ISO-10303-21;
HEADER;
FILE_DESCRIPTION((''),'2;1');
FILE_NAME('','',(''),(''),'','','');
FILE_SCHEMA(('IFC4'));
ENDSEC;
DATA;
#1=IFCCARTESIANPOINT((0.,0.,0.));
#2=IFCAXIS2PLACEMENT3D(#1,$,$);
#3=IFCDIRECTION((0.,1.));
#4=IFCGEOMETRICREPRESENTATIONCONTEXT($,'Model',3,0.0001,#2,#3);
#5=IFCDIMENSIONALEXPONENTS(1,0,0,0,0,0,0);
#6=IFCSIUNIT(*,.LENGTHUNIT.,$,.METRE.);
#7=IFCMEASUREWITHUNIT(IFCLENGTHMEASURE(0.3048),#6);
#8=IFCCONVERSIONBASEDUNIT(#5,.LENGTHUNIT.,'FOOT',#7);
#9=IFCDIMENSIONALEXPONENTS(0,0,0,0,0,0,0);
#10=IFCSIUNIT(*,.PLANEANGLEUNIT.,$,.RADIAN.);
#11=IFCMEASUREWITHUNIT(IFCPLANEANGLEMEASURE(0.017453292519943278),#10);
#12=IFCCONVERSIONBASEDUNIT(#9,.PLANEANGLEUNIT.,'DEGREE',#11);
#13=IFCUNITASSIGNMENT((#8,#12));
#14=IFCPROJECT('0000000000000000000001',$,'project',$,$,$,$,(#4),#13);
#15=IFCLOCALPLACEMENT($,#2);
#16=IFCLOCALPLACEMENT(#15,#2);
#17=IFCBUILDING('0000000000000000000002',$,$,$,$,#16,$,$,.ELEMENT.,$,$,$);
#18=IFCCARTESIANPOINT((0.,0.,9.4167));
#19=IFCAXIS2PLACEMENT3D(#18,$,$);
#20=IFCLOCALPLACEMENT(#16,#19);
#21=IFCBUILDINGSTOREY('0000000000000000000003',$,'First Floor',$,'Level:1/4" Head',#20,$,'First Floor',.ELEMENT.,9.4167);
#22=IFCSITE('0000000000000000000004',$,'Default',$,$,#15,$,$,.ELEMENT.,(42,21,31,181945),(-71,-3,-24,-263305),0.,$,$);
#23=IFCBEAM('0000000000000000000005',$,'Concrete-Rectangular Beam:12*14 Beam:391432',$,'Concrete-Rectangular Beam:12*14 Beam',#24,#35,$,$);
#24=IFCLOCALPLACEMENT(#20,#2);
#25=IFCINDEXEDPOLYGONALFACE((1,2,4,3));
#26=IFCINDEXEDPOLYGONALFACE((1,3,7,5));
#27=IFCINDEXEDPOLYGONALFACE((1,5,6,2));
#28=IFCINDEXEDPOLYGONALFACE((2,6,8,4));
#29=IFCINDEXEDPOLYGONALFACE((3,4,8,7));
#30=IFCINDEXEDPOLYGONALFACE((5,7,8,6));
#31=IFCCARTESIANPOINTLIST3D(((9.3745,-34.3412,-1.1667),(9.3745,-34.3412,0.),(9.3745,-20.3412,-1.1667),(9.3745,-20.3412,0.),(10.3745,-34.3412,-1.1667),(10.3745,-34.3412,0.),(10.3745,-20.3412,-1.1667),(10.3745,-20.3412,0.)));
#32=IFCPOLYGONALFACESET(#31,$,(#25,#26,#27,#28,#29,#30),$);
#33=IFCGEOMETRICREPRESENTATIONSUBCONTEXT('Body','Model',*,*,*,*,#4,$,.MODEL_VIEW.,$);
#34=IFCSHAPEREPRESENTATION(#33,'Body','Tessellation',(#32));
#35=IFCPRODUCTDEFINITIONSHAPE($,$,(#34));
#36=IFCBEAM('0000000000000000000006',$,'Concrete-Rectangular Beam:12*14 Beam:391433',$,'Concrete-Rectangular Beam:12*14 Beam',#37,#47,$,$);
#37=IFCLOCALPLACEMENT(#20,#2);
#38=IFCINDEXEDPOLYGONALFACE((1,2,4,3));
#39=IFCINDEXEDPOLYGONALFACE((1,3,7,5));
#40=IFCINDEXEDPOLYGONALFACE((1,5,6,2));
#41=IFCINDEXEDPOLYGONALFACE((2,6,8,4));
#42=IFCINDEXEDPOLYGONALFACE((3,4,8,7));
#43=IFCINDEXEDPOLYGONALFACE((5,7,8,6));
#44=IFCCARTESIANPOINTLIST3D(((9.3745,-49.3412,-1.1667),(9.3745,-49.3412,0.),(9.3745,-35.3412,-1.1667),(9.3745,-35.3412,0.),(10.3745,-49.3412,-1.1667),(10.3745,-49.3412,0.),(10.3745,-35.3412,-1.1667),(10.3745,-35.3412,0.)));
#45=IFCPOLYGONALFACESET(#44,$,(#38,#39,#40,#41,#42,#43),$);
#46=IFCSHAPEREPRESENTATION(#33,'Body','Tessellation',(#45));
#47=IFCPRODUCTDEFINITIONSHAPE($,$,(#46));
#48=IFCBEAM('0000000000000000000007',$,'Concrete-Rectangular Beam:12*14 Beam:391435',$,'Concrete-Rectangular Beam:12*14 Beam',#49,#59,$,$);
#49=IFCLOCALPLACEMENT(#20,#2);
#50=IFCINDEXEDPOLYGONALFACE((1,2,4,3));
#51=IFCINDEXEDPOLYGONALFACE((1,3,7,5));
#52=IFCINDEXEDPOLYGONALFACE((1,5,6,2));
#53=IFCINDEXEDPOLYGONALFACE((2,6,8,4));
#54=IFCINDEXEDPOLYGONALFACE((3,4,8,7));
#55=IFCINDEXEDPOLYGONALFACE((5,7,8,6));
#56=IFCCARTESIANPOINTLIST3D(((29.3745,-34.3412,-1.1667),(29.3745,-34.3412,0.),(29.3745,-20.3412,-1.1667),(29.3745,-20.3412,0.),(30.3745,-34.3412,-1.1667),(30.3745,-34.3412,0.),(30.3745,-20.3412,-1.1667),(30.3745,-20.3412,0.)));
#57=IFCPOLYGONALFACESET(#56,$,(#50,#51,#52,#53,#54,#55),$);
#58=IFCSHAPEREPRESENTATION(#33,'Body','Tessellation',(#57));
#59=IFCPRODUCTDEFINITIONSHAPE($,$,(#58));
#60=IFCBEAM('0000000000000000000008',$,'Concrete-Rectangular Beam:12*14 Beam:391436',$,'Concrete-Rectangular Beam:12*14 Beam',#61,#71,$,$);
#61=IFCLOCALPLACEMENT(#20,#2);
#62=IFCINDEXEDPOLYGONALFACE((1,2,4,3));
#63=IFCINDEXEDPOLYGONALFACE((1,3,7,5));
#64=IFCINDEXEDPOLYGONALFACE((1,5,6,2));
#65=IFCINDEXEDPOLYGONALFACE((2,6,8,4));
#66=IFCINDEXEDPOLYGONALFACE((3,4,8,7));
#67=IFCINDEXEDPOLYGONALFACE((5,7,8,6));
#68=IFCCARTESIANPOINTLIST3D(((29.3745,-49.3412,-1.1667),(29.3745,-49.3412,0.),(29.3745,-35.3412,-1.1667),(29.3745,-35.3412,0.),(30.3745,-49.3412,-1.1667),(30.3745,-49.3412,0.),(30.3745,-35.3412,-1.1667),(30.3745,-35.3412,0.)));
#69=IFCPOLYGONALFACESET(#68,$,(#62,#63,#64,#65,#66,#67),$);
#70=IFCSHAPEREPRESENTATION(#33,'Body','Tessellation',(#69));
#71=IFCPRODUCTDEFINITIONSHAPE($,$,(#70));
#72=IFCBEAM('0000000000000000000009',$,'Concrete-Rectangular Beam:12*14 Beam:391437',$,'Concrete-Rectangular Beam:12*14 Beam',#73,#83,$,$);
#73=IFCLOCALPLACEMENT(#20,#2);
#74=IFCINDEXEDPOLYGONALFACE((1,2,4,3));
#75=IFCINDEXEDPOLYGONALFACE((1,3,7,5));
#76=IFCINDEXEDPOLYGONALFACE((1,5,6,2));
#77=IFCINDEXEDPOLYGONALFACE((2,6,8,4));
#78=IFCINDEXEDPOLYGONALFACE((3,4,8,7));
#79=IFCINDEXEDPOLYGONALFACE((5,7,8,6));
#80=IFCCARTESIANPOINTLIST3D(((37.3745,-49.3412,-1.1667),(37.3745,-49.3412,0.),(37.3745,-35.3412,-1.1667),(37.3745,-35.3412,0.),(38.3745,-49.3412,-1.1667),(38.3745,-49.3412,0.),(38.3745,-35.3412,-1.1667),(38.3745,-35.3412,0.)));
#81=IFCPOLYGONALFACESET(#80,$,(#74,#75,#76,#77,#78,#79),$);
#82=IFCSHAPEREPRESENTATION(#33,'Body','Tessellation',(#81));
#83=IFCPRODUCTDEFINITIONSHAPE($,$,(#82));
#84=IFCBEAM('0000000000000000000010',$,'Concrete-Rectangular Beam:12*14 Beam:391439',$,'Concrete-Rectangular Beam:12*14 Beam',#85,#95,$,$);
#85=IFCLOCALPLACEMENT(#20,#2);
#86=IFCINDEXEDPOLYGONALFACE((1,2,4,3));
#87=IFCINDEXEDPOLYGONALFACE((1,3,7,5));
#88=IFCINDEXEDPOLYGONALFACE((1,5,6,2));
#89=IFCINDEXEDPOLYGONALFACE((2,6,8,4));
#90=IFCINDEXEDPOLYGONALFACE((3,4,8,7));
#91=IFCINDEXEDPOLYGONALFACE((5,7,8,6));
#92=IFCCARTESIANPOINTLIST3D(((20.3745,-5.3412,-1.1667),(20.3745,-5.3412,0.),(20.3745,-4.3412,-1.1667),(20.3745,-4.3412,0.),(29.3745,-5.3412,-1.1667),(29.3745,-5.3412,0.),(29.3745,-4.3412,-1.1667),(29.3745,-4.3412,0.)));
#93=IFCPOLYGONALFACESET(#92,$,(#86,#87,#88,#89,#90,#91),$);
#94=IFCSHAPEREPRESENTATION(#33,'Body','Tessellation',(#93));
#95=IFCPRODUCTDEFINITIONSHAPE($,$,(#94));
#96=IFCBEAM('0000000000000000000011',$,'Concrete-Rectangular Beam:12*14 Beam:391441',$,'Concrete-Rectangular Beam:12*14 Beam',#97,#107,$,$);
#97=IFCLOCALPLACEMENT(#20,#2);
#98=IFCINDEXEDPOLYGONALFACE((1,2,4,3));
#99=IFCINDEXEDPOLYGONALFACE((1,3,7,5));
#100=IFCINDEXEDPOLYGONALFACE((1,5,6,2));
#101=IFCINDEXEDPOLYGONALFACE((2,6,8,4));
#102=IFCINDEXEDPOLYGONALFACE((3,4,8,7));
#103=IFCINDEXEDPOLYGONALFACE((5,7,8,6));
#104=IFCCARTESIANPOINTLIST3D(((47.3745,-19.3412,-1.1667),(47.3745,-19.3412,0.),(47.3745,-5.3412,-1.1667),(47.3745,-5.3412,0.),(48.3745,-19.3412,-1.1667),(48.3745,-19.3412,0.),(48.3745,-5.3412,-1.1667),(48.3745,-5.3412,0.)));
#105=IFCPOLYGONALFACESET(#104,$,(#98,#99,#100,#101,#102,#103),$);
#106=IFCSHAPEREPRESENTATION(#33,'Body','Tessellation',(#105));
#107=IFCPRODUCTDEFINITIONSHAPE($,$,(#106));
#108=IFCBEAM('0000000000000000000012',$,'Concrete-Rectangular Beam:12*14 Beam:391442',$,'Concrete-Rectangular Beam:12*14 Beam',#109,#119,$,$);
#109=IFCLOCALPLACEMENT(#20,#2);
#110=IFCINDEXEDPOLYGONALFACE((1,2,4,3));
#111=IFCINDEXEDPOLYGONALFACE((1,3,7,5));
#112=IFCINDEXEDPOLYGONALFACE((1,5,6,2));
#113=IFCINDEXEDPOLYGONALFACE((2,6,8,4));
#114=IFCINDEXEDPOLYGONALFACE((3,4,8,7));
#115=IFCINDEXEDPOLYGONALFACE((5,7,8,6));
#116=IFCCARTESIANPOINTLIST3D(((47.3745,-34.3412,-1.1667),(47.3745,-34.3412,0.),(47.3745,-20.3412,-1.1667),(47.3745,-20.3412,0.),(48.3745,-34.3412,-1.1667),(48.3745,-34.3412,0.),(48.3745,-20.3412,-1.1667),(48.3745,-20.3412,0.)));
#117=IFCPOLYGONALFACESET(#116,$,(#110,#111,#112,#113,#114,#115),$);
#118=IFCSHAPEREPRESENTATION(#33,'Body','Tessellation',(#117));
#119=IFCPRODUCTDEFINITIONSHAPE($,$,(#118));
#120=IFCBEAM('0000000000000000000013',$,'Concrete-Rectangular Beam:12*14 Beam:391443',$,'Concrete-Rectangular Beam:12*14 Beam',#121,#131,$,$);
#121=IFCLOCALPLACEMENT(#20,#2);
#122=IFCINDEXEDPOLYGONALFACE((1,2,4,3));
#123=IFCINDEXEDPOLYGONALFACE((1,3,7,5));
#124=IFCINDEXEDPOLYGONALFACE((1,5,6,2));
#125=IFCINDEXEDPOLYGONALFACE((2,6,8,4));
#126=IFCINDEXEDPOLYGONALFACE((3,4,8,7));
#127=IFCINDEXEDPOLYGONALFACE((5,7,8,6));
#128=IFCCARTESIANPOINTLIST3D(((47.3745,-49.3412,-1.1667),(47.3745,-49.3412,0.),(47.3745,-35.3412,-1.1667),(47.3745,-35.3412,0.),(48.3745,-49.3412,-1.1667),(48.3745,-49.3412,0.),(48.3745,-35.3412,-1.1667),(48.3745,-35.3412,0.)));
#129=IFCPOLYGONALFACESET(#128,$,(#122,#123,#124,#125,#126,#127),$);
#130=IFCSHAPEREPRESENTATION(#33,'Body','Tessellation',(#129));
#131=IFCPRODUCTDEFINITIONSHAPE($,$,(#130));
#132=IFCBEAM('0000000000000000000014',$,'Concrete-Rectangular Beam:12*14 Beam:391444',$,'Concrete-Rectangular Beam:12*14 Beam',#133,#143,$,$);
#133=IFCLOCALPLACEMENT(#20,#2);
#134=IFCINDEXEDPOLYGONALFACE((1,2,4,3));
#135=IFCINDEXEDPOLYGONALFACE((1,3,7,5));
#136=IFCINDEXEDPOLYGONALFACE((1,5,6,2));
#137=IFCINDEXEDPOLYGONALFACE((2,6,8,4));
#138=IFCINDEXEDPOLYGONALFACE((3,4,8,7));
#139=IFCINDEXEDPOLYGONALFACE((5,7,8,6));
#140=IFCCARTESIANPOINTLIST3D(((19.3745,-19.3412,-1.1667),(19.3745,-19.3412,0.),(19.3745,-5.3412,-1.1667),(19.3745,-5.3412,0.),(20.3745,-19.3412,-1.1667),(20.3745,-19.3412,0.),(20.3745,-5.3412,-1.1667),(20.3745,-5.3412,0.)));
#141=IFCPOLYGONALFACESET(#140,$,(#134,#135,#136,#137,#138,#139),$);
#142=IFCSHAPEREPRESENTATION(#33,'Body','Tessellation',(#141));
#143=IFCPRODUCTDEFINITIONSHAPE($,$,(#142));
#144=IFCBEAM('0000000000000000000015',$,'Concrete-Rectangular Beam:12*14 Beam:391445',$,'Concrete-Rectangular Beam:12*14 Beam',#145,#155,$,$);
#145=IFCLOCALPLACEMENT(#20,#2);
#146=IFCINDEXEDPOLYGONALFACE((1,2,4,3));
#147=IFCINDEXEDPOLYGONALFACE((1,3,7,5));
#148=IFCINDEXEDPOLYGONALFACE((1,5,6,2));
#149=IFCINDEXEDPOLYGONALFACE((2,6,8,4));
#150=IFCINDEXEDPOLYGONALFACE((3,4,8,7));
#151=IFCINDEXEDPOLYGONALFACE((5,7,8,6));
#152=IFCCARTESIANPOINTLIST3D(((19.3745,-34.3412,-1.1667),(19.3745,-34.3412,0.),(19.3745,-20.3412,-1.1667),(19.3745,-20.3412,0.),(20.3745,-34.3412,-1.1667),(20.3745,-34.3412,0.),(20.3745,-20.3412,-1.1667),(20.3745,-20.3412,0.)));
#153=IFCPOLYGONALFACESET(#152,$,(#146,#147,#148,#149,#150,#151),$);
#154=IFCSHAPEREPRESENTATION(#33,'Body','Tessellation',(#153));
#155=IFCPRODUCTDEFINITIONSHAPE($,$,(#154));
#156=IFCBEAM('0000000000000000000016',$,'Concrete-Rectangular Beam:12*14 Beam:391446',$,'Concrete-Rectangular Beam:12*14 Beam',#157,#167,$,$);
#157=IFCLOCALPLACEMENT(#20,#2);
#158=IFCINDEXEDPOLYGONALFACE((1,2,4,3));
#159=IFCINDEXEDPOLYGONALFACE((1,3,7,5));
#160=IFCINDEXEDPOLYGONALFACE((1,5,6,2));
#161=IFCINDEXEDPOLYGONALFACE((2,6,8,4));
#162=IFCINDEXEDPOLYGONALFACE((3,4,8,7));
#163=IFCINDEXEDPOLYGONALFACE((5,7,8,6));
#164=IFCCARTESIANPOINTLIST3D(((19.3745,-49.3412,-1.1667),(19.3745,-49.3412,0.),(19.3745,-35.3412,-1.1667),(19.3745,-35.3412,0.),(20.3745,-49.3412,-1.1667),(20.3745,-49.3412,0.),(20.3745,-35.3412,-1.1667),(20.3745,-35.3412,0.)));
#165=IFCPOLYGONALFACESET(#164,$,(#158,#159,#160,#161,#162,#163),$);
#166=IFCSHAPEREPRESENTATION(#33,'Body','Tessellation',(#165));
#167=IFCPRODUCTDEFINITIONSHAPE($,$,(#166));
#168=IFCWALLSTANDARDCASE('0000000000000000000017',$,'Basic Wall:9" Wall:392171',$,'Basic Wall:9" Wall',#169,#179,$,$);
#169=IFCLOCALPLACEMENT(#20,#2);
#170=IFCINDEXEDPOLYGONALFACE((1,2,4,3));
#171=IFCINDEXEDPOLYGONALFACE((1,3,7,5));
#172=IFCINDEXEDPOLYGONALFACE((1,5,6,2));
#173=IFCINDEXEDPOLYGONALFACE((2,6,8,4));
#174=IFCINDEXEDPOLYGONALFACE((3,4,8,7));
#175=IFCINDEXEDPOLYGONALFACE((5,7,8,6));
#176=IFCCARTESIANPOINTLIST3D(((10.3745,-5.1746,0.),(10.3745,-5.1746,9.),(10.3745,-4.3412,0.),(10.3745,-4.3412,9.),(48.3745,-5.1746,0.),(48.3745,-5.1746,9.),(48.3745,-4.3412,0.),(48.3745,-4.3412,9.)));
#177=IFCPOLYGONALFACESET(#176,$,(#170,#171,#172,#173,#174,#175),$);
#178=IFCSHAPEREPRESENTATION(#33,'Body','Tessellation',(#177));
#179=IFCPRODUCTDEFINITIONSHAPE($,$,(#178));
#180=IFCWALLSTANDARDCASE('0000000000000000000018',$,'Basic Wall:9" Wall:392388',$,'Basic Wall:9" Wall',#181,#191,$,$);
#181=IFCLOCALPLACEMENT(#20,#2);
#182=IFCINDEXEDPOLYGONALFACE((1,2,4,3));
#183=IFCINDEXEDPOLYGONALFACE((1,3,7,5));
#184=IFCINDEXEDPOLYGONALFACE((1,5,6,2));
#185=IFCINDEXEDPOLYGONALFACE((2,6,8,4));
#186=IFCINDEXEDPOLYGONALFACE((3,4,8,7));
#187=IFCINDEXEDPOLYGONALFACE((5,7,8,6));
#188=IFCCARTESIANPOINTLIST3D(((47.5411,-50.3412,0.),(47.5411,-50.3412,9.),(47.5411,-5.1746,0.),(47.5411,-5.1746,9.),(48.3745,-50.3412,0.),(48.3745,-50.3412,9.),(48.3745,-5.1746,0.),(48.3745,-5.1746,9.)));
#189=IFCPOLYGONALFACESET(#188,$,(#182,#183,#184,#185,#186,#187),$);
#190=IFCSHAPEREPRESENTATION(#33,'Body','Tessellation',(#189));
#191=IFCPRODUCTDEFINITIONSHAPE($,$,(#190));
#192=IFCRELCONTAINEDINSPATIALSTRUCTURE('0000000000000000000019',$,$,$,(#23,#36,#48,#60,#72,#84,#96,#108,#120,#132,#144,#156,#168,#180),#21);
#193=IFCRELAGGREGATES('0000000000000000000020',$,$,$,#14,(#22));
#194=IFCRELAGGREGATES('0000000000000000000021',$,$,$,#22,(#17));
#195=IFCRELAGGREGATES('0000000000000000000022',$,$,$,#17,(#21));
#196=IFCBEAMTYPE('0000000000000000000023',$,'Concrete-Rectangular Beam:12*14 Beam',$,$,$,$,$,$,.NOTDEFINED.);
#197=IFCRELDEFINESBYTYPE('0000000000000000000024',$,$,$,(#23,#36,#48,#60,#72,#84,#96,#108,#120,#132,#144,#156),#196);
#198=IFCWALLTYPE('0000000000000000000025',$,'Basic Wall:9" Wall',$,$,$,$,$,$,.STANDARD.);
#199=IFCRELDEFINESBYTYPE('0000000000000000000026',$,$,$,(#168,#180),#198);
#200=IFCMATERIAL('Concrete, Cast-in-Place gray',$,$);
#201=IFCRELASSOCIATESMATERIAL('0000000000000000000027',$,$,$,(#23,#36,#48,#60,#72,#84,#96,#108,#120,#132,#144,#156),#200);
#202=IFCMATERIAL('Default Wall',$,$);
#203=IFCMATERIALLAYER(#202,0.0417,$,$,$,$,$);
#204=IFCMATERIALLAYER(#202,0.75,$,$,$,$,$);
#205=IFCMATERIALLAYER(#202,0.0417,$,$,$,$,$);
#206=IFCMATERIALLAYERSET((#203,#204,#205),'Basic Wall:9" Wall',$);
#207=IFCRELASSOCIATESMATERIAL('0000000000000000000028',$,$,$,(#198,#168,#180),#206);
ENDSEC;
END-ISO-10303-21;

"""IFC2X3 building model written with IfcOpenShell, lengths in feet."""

from ifc_helpers import new_model, entity, si_unit, converted_unit, direction, frame, frame_2d, origin, place, context, subcontext, project, spatial, rectangle, extrude, material, layer, layer_set, layer_usage, type_object, element, save


model = new_model("IFC2X3")

# Units and contexts
model_context = context("Model", 3, precision=0.0001, world=origin(), true_north=direction((0.0, 1.0)))
body_context = subcontext(model_context, "Body", "Model", "MODEL_VIEW")
ifc_project = project(units=[converted_unit("LENGTHUNIT", "FOOT", entity("IfcLengthMeasure", 0.3048), si_unit("LENGTHUNIT", "METRE"), dimensions=[1, 0, 0, 0, 0, 0, 0]), converted_unit("PLANEANGLEUNIT", "DEGREE", entity("IfcPlaneAngleMeasure", 0.017453292519943278), si_unit("PLANEANGLEUNIT", "RADIAN"), dimensions=[0, 0, 0, 0, 0, 0, 0])], contexts=[model_context])

# Site, building, storey
site_placement = place(None, origin())
site = spatial("IfcSite", under=ifc_project, at=site_placement, Name="Default", CompositionType="ELEMENT", RefLatitude=(42, 21, 31, 181945), RefLongitude=(-71, -3, -24, -263305), RefElevation=0.0)
building_placement = place(site_placement, origin())
building = spatial("IfcBuilding", under=site, at=building_placement, CompositionType="ELEMENT")
storey_placement = place(building_placement, frame((0.0, 0.0, 9.4167)))
storey = spatial("IfcBuildingStorey", under=building, at=storey_placement, Name="First Floor", ObjectType="Level:1/4\" Head", LongName="First Floor", CompositionType="ELEMENT", Elevation=9.4167)

# Shared definitions
ifc_material_1 = material(Name="Concrete, Cast-in-Place gray")

# Beams
beam_type = type_object("IfcBeamType", Name="Concrete-Rectangular Beam:12*14 Beam", PredefinedType="NOTDEFINED")
beam_1_placement = place(storey_placement, frame((9.8745, -19.8412, 0.0), z_axis=(0.0, 0.0, 1.0), x_axis=(0.0, -1.0, 0.0)))
element("IfcBeam", 1, at=beam_1_placement, inside=storey, type_object=beam_type, material=ifc_material_1, Name="Concrete-Rectangular Beam:12*14 Beam:391432", ObjectType="Concrete-Rectangular Beam:12*14 Beam", context=body_context, shape_type="SweptSolid", body=[
    extrude(rectangle(XDim=1.1667, YDim=1.0, at=frame_2d((0.0, 0.0), x_axis=(1.0, 0.0))), frame((0.5, 0.0, -0.5833), z_axis=(1.0, 0.0, 0.0), x_axis=(0.0, 0.0, -1.0)), (0.0, 0.0, 1.0), 14.0),
])
beam_2_placement = place(storey_placement, frame((9.8745, -34.8412, 0.0), z_axis=(0.0, 0.0, 1.0), x_axis=(0.0, -1.0, 0.0)))
element("IfcBeam", 2, at=beam_2_placement, inside=storey, type_object=beam_type, material=ifc_material_1, Name="Concrete-Rectangular Beam:12*14 Beam:391433", ObjectType="Concrete-Rectangular Beam:12*14 Beam", context=body_context, shape_type="SweptSolid", body=[
    extrude(rectangle(XDim=1.1667, YDim=1.0, at=frame_2d((0.0, 0.0), x_axis=(1.0, 0.0))), frame((0.5, 0.0, -0.5833), z_axis=(1.0, 0.0, 0.0), x_axis=(0.0, 0.0, -1.0)), (0.0, 0.0, 1.0), 14.0),
])
beam_3_placement = place(storey_placement, frame((29.8745, -19.8412, 0.0), z_axis=(0.0, 0.0, 1.0), x_axis=(0.0, -1.0, 0.0)))
element("IfcBeam", 3, at=beam_3_placement, inside=storey, type_object=beam_type, material=ifc_material_1, Name="Concrete-Rectangular Beam:12*14 Beam:391435", ObjectType="Concrete-Rectangular Beam:12*14 Beam", context=body_context, shape_type="SweptSolid", body=[
    extrude(rectangle(XDim=1.1667, YDim=1.0, at=frame_2d((0.0, 0.0), x_axis=(1.0, 0.0))), frame((0.5, 0.0, -0.5833), z_axis=(1.0, 0.0, 0.0), x_axis=(0.0, 0.0, -1.0)), (0.0, 0.0, 1.0), 14.0),
])
beam_4_placement = place(storey_placement, frame((29.8745, -34.8412, 0.0), z_axis=(0.0, 0.0, 1.0), x_axis=(0.0, -1.0, 0.0)))
element("IfcBeam", 4, at=beam_4_placement, inside=storey, type_object=beam_type, material=ifc_material_1, Name="Concrete-Rectangular Beam:12*14 Beam:391436", ObjectType="Concrete-Rectangular Beam:12*14 Beam", context=body_context, shape_type="SweptSolid", body=[
    extrude(rectangle(XDim=1.1667, YDim=1.0, at=frame_2d((0.0, 0.0), x_axis=(1.0, 0.0))), frame((0.5, 0.0, -0.5833), z_axis=(1.0, 0.0, 0.0), x_axis=(0.0, 0.0, -1.0)), (0.0, 0.0, 1.0), 14.0),
])
beam_5_placement = place(storey_placement, frame((37.8745, -34.8412, 0.0), z_axis=(0.0, 0.0, 1.0), x_axis=(0.0, -1.0, 0.0)))
element("IfcBeam", 5, at=beam_5_placement, inside=storey, type_object=beam_type, material=ifc_material_1, Name="Concrete-Rectangular Beam:12*14 Beam:391437", ObjectType="Concrete-Rectangular Beam:12*14 Beam", context=body_context, shape_type="SweptSolid", body=[
    extrude(rectangle(XDim=1.1667, YDim=1.0, at=frame_2d((0.0, 0.0), x_axis=(1.0, 0.0))), frame((0.5, 0.0, -0.5833), z_axis=(1.0, 0.0, 0.0), x_axis=(0.0, 0.0, -1.0)), (0.0, 0.0, 1.0), 14.0),
])
beam_6_placement = place(storey_placement, frame((19.8745, -4.8412, 0.0)))
element("IfcBeam", 6, at=beam_6_placement, inside=storey, type_object=beam_type, material=ifc_material_1, Name="Concrete-Rectangular Beam:12*14 Beam:391439", ObjectType="Concrete-Rectangular Beam:12*14 Beam", context=body_context, shape_type="SweptSolid", body=[
    extrude(rectangle(XDim=1.1667, YDim=1.0, at=frame_2d((0.0, 0.0), x_axis=(1.0, 0.0))), frame((0.5, 0.0, -0.5833), z_axis=(1.0, 0.0, 0.0), x_axis=(0.0, 0.0, -1.0)), (0.0, 0.0, 1.0), 9.0),
])
beam_7_placement = place(storey_placement, frame((47.8745, -4.8412, 0.0), z_axis=(0.0, 0.0, 1.0), x_axis=(0.0, -1.0, 0.0)))
element("IfcBeam", 7, at=beam_7_placement, inside=storey, type_object=beam_type, material=ifc_material_1, Name="Concrete-Rectangular Beam:12*14 Beam:391441", ObjectType="Concrete-Rectangular Beam:12*14 Beam", context=body_context, shape_type="SweptSolid", body=[
    extrude(rectangle(XDim=1.1667, YDim=1.0, at=frame_2d((0.0, 0.0), x_axis=(1.0, 0.0))), frame((0.5, 0.0, -0.5833), z_axis=(1.0, 0.0, 0.0), x_axis=(0.0, 0.0, -1.0)), (0.0, 0.0, 1.0), 14.0),
])
beam_8_placement = place(storey_placement, frame((47.8745, -19.8412, 0.0), z_axis=(0.0, 0.0, 1.0), x_axis=(0.0, -1.0, 0.0)))
element("IfcBeam", 8, at=beam_8_placement, inside=storey, type_object=beam_type, material=ifc_material_1, Name="Concrete-Rectangular Beam:12*14 Beam:391442", ObjectType="Concrete-Rectangular Beam:12*14 Beam", context=body_context, shape_type="SweptSolid", body=[
    extrude(rectangle(XDim=1.1667, YDim=1.0, at=frame_2d((0.0, 0.0), x_axis=(1.0, 0.0))), frame((0.5, 0.0, -0.5833), z_axis=(1.0, 0.0, 0.0), x_axis=(0.0, 0.0, -1.0)), (0.0, 0.0, 1.0), 14.0),
])
beam_9_placement = place(storey_placement, frame((47.8745, -34.8412, 0.0), z_axis=(0.0, 0.0, 1.0), x_axis=(0.0, -1.0, 0.0)))
element("IfcBeam", 9, at=beam_9_placement, inside=storey, type_object=beam_type, material=ifc_material_1, Name="Concrete-Rectangular Beam:12*14 Beam:391443", ObjectType="Concrete-Rectangular Beam:12*14 Beam", context=body_context, shape_type="SweptSolid", body=[
    extrude(rectangle(XDim=1.1667, YDim=1.0, at=frame_2d((0.0, 0.0), x_axis=(1.0, 0.0))), frame((0.5, 0.0, -0.5833), z_axis=(1.0, 0.0, 0.0), x_axis=(0.0, 0.0, -1.0)), (0.0, 0.0, 1.0), 14.0),
])
beam_10_placement = place(storey_placement, frame((19.8745, -4.8412, 0.0), z_axis=(0.0, 0.0, 1.0), x_axis=(0.0, -1.0, 0.0)))
element("IfcBeam", 10, at=beam_10_placement, inside=storey, type_object=beam_type, material=ifc_material_1, Name="Concrete-Rectangular Beam:12*14 Beam:391444", ObjectType="Concrete-Rectangular Beam:12*14 Beam", context=body_context, shape_type="SweptSolid", body=[
    extrude(rectangle(XDim=1.1667, YDim=1.0, at=frame_2d((0.0, 0.0), x_axis=(1.0, 0.0))), frame((0.5, 0.0, -0.5833), z_axis=(1.0, 0.0, 0.0), x_axis=(0.0, 0.0, -1.0)), (0.0, 0.0, 1.0), 14.0),
])
beam_11_placement = place(storey_placement, frame((19.8745, -19.8412, 0.0), z_axis=(0.0, 0.0, 1.0), x_axis=(0.0, -1.0, 0.0)))
element("IfcBeam", 11, at=beam_11_placement, inside=storey, type_object=beam_type, material=ifc_material_1, Name="Concrete-Rectangular Beam:12*14 Beam:391445", ObjectType="Concrete-Rectangular Beam:12*14 Beam", context=body_context, shape_type="SweptSolid", body=[
    extrude(rectangle(XDim=1.1667, YDim=1.0, at=frame_2d((0.0, 0.0), x_axis=(1.0, 0.0))), frame((0.5, 0.0, -0.5833), z_axis=(1.0, 0.0, 0.0), x_axis=(0.0, 0.0, -1.0)), (0.0, 0.0, 1.0), 14.0),
])
beam_12_placement = place(storey_placement, frame((19.8745, -34.8412, 0.0), z_axis=(0.0, 0.0, 1.0), x_axis=(0.0, -1.0, 0.0)))
element("IfcBeam", 12, at=beam_12_placement, inside=storey, type_object=beam_type, material=ifc_material_1, Name="Concrete-Rectangular Beam:12*14 Beam:391446", ObjectType="Concrete-Rectangular Beam:12*14 Beam", context=body_context, shape_type="SweptSolid", body=[
    extrude(rectangle(XDim=1.1667, YDim=1.0, at=frame_2d((0.0, 0.0), x_axis=(1.0, 0.0))), frame((0.5, 0.0, -0.5833), z_axis=(1.0, 0.0, 0.0), x_axis=(0.0, 0.0, -1.0)), (0.0, 0.0, 1.0), 14.0),
])

# Walls
ifc_material_2 = material(Name="Default Wall")
ifc_layer_1 = layer(ifc_material_2, 0.0417)
ifc_layer_2 = layer(ifc_material_2, 0.75)
ifc_layer_3 = layer(ifc_material_2, 0.0417)
ifc_layer_set_1 = layer_set([ifc_layer_1, ifc_layer_2, ifc_layer_3], Name="Basic Wall:9\" Wall")
ifc_layer_usage_1 = layer_usage(ifc_layer_set_1, "AXIS2", "NEGATIVE", 0.4167)
wall_type_1 = type_object("IfcWallType", Name="Basic Wall:9\" Wall", PredefinedType="STANDARD", material=ifc_layer_set_1)
wall_1_placement = place(storey_placement, frame((10.3745, -4.7579, 0.0)))
element("IfcWallStandardCase", 13, at=wall_1_placement, inside=storey, type_object=wall_type_1, material=ifc_layer_usage_1, Name="Basic Wall:9\" Wall:392171", ObjectType="Basic Wall:9\" Wall", context=body_context, shape_type="SweptSolid", body=[
    extrude(rectangle(XDim=38.0, YDim=0.8333, at=frame_2d((19.0, 0.0), x_axis=(-1.0, 0.0))), origin(), (0.0, 0.0, 1.0), 9.0),
])
wall_2_placement = place(storey_placement, frame((47.9578, -5.1746, 0.0), z_axis=(0.0, 0.0, 1.0), x_axis=(0.0, -1.0, 0.0)))
element("IfcWallStandardCase", 14, at=wall_2_placement, inside=storey, type_object=wall_type_1, material=ifc_layer_usage_1, Name="Basic Wall:9\" Wall:392388", ObjectType="Basic Wall:9\" Wall", context=body_context, shape_type="SweptSolid", body=[
    extrude(rectangle(XDim=45.1667, YDim=0.8333, at=frame_2d((22.5833, 0.0), x_axis=(-1.0, 0.0))), origin(), (0.0, 0.0, 1.0), 9.0),
])

save(model, "model.ifc")
